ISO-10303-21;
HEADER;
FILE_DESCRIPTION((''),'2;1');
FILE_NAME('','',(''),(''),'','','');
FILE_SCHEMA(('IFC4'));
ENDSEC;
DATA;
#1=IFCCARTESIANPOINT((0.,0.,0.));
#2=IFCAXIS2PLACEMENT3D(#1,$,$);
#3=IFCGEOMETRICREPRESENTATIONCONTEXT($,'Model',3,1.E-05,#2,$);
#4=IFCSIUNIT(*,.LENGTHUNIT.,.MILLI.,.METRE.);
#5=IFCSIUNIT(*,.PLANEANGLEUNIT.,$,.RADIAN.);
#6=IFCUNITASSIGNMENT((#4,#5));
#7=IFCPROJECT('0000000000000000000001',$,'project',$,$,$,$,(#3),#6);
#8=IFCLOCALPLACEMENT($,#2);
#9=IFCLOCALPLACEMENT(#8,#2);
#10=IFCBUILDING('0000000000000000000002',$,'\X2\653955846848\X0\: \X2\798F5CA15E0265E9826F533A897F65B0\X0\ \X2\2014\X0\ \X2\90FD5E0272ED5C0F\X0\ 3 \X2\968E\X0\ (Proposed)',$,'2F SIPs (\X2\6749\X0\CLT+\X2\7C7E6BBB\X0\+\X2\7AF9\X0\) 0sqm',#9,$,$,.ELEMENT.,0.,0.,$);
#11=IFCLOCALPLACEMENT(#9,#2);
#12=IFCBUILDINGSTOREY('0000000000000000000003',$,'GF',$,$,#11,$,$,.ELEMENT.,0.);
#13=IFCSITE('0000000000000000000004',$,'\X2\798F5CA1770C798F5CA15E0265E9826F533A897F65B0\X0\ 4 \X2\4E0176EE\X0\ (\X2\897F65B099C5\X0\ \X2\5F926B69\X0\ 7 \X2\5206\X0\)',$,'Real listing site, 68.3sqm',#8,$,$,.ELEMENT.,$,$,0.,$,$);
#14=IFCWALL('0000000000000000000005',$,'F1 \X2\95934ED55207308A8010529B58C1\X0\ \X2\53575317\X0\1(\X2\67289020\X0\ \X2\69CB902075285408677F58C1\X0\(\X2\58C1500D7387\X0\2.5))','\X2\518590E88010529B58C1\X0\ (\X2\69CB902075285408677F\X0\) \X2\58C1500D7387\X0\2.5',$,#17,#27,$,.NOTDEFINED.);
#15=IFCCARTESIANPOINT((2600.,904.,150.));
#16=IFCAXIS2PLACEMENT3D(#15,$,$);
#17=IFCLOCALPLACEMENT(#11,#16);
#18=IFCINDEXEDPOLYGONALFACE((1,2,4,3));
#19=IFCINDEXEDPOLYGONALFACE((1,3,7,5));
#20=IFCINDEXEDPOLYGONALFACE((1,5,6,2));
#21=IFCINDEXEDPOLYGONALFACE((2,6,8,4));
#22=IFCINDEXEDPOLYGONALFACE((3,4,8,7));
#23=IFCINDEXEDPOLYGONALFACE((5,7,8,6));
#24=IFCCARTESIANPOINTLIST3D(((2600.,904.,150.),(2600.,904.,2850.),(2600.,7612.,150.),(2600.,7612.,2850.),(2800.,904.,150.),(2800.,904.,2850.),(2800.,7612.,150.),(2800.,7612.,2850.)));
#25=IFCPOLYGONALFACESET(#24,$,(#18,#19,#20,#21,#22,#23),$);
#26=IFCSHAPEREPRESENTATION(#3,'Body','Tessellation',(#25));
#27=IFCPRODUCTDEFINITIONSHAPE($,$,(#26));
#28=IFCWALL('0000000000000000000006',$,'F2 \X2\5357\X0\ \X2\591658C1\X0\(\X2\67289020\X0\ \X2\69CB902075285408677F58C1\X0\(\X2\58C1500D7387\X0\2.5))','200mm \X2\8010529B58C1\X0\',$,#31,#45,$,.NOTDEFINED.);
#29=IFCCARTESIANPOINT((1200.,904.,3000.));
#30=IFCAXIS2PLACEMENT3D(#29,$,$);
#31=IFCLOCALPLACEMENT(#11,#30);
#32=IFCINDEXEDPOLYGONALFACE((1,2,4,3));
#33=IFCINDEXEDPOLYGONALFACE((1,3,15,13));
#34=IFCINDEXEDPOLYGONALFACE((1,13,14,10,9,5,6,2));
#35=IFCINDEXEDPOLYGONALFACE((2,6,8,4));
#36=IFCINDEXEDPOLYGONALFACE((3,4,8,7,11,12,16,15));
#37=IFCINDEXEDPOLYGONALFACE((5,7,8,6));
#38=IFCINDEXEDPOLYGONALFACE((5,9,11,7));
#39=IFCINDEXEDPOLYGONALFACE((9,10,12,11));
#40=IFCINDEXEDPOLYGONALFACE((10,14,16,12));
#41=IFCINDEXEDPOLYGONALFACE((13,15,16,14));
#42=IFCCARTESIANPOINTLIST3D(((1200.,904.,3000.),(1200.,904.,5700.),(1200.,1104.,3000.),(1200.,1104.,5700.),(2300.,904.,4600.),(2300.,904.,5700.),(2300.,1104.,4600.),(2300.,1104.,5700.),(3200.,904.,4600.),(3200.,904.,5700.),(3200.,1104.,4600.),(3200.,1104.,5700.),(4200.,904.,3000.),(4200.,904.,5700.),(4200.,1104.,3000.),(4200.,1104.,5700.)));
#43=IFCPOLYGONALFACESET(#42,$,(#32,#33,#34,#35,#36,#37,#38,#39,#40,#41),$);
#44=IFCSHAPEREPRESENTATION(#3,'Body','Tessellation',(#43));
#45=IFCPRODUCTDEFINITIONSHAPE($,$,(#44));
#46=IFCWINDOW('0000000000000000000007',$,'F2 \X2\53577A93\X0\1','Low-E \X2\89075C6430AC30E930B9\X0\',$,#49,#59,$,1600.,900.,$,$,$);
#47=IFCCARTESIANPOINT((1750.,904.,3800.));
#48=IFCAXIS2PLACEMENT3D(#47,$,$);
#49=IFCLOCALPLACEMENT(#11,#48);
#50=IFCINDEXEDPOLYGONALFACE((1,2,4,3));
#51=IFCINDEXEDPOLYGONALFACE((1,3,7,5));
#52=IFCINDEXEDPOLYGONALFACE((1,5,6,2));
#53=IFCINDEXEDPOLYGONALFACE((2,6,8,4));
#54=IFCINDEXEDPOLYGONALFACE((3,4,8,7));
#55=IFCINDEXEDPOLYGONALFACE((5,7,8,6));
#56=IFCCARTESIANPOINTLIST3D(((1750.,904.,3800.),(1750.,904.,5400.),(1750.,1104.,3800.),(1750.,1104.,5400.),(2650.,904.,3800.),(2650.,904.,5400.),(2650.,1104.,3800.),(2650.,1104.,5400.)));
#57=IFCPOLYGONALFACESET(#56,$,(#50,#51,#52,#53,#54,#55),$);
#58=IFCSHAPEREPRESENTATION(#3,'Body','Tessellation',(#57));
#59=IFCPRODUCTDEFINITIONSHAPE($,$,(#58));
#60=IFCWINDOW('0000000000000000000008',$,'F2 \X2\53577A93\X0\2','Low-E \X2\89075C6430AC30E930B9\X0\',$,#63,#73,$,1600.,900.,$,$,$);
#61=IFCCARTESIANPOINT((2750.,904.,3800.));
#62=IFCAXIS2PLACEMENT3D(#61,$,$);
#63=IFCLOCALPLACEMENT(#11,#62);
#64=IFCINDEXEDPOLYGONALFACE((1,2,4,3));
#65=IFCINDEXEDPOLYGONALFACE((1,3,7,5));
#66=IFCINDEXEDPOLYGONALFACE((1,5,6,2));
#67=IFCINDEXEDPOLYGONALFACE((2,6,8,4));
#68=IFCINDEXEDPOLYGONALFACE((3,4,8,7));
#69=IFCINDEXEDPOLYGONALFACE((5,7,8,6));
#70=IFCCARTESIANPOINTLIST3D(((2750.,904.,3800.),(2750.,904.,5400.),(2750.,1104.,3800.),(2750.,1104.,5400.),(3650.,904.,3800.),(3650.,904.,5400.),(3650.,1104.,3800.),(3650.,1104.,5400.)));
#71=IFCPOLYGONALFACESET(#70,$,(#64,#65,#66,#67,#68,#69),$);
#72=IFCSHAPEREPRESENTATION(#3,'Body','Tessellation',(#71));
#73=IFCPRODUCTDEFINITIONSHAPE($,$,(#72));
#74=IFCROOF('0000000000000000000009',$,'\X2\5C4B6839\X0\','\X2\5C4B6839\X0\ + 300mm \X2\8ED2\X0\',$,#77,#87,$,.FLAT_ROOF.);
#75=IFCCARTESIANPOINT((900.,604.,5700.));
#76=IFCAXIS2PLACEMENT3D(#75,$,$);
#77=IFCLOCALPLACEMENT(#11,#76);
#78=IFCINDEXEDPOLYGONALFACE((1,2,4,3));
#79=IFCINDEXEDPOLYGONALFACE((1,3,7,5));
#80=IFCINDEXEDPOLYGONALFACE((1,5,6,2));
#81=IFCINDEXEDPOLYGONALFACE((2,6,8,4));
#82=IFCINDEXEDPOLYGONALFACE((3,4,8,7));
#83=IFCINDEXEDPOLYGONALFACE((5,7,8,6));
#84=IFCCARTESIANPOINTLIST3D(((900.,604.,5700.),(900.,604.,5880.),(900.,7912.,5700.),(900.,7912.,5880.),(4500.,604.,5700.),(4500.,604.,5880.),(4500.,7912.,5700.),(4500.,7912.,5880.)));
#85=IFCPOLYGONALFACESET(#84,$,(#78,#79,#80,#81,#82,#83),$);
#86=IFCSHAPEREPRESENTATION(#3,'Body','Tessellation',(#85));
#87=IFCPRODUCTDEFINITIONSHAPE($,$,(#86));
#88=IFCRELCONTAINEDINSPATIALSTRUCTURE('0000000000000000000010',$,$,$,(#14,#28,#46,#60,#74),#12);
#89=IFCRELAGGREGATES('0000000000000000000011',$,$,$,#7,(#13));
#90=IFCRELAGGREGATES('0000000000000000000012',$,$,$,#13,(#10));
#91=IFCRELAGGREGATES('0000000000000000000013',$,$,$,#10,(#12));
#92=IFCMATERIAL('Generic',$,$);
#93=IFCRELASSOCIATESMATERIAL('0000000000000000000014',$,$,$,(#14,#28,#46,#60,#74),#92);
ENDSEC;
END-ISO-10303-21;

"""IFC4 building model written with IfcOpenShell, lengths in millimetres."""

from ifc_helpers import new_model, si_unit, frame, frame_2d, origin, place, context, project, spatial, rectangle, extrude, material, element, fill, save


model = new_model("IFC4")

# Units and contexts
model_context = context("Model", 3, precision=1e-05, world=origin())
ifc_project = project(units=[si_unit("LENGTHUNIT", "METRE", prefix="MILLI"), si_unit("PLANEANGLEUNIT", "RADIAN")], contexts=[model_context])

# Site, building, storey
site_placement = place(None, origin())
site = spatial("IfcSite", under=ifc_project, at=site_placement, Name="福岡県福岡市早良区西新 4 丁目 (西新駅 徒歩 7 分)", ObjectType="Real listing site, 68.3sqm", CompositionType="ELEMENT", RefElevation=0.0)
building_placement = place(site_placement, origin())
building = spatial("IfcBuilding", under=site, at=building_placement, Name="改善案: 福岡市早良区西新 — 都市狭小 3 階 (Proposed)", ObjectType="2F SIPs (杉CLT+籾殻+竹) 0sqm", CompositionType="ELEMENT", ElevationOfRefHeight=0.0, ElevationOfTerrain=0.0)
storey_placement = place(building_placement, origin())
storey = spatial("IfcBuildingStorey", under=building, at=storey_placement, Name="GF", CompositionType="ELEMENT", Elevation=0.0)

# Shared definitions
ifc_material_1 = material(Name="Generic")

# Wall
wall_1_placement = place(storey_placement, frame((2600.0, 904.0, 150.0)))
element("IfcWall", 1, at=wall_1_placement, inside=storey, material=ifc_material_1, Name="F1 間仕切り耐力壁 南北1(木造 構造用合板壁(壁倍率2.5))", Description="内部耐力壁 (構造用合板) 壁倍率2.5", PredefinedType="NOTDEFINED", context=model_context, shape_type="SweptSolid", body=[
    extrude(rectangle(XDim=200.0, YDim=6708.0, at=frame_2d((100.0, 3354.0))), frame((2600.0, 904.0, 150.0)), (0.0, 0.0, 1.0), 2700.0),
])

# Wall, openings, windows
wall_2_placement = place(storey_placement, frame((1200.0, 904.0, 3000.0)))
wall_2 = element("IfcWall", 2, at=wall_2_placement, inside=storey, material=ifc_material_1, Name="F2 南 外壁(木造 構造用合板壁(壁倍率2.5))", Description="200mm 耐力壁", PredefinedType="NOTDEFINED", context=model_context, shape_type="SweptSolid", body=[
    extrude(rectangle(XDim=3000.0, YDim=200.0, at=frame_2d((1500.0, 100.0))), frame((1200.0, 904.0, 3000.0)), (0.0, 0.0, 1.0), 2700.0),
])
opening_1_placement = place(storey_placement, frame((1750.0, 904.0, 3800.0)))
opening_1 = element("IfcOpeningElement", 3, at=opening_1_placement, cuts=wall_2, PredefinedType="NOTDEFINED", context=model_context, shape_type="SweptSolid", body=[
    extrude(rectangle(XDim=900.0, YDim=200.0, at=frame_2d((450.0, 100.0))), frame((1750.0, 904.0, 3800.0)), (0.0, 0.0, 1.0), 1600.0),
])
opening_2_placement = place(storey_placement, frame((2750.0, 904.0, 3800.0)))
opening_2 = element("IfcOpeningElement", 4, at=opening_2_placement, cuts=wall_2, PredefinedType="NOTDEFINED", context=model_context, shape_type="SweptSolid", body=[
    extrude(rectangle(XDim=900.0, YDim=200.0, at=frame_2d((450.0, 100.0))), frame((2750.0, 904.0, 3800.0)), (0.0, 0.0, 1.0), 1600.0),
])
window_1_placement = place(storey_placement, frame((1750.0, 904.0, 3800.0)))
window_1 = element("IfcWindow", 5, at=window_1_placement, inside=storey, material=ifc_material_1, Name="F2 南窓1", Description="Low-E 複層ガラス", OverallHeight=1600.0, OverallWidth=900.0, context=model_context, shape_type="SweptSolid", body=[
    extrude(rectangle(XDim=900.0, YDim=200.0, at=frame_2d((450.0, 100.0))), frame((1750.0, 904.0, 3800.0)), (0.0, 0.0, 1.0), 1600.0),
])
fill(opening_1, window_1)
window_2_placement = place(storey_placement, frame((2750.0, 904.0, 3800.0)))
window_2 = element("IfcWindow", 6, at=window_2_placement, inside=storey, material=ifc_material_1, Name="F2 南窓2", Description="Low-E 複層ガラス", OverallHeight=1600.0, OverallWidth=900.0, context=model_context, shape_type="SweptSolid", body=[
    extrude(rectangle(XDim=900.0, YDim=200.0, at=frame_2d((450.0, 100.0))), frame((2750.0, 904.0, 3800.0)), (0.0, 0.0, 1.0), 1600.0),
])
fill(opening_2, window_2)

# Roof
roof_placement = place(storey_placement, frame((900.0, 604.0, 5700.0)))
element("IfcRoof", 7, at=roof_placement, inside=storey, material=ifc_material_1, Name="屋根", Description="屋根 + 300mm 軒", PredefinedType="FLAT_ROOF", context=model_context, shape_type="SweptSolid", body=[
    extrude(rectangle(XDim=3600.0, YDim=7308.0, at=frame_2d((1800.0, 3654.0))), frame((900.0, 604.0, 5700.0)), (0.0, 0.0, 1.0), 180.0),
])

save(model, "model.ifc")
